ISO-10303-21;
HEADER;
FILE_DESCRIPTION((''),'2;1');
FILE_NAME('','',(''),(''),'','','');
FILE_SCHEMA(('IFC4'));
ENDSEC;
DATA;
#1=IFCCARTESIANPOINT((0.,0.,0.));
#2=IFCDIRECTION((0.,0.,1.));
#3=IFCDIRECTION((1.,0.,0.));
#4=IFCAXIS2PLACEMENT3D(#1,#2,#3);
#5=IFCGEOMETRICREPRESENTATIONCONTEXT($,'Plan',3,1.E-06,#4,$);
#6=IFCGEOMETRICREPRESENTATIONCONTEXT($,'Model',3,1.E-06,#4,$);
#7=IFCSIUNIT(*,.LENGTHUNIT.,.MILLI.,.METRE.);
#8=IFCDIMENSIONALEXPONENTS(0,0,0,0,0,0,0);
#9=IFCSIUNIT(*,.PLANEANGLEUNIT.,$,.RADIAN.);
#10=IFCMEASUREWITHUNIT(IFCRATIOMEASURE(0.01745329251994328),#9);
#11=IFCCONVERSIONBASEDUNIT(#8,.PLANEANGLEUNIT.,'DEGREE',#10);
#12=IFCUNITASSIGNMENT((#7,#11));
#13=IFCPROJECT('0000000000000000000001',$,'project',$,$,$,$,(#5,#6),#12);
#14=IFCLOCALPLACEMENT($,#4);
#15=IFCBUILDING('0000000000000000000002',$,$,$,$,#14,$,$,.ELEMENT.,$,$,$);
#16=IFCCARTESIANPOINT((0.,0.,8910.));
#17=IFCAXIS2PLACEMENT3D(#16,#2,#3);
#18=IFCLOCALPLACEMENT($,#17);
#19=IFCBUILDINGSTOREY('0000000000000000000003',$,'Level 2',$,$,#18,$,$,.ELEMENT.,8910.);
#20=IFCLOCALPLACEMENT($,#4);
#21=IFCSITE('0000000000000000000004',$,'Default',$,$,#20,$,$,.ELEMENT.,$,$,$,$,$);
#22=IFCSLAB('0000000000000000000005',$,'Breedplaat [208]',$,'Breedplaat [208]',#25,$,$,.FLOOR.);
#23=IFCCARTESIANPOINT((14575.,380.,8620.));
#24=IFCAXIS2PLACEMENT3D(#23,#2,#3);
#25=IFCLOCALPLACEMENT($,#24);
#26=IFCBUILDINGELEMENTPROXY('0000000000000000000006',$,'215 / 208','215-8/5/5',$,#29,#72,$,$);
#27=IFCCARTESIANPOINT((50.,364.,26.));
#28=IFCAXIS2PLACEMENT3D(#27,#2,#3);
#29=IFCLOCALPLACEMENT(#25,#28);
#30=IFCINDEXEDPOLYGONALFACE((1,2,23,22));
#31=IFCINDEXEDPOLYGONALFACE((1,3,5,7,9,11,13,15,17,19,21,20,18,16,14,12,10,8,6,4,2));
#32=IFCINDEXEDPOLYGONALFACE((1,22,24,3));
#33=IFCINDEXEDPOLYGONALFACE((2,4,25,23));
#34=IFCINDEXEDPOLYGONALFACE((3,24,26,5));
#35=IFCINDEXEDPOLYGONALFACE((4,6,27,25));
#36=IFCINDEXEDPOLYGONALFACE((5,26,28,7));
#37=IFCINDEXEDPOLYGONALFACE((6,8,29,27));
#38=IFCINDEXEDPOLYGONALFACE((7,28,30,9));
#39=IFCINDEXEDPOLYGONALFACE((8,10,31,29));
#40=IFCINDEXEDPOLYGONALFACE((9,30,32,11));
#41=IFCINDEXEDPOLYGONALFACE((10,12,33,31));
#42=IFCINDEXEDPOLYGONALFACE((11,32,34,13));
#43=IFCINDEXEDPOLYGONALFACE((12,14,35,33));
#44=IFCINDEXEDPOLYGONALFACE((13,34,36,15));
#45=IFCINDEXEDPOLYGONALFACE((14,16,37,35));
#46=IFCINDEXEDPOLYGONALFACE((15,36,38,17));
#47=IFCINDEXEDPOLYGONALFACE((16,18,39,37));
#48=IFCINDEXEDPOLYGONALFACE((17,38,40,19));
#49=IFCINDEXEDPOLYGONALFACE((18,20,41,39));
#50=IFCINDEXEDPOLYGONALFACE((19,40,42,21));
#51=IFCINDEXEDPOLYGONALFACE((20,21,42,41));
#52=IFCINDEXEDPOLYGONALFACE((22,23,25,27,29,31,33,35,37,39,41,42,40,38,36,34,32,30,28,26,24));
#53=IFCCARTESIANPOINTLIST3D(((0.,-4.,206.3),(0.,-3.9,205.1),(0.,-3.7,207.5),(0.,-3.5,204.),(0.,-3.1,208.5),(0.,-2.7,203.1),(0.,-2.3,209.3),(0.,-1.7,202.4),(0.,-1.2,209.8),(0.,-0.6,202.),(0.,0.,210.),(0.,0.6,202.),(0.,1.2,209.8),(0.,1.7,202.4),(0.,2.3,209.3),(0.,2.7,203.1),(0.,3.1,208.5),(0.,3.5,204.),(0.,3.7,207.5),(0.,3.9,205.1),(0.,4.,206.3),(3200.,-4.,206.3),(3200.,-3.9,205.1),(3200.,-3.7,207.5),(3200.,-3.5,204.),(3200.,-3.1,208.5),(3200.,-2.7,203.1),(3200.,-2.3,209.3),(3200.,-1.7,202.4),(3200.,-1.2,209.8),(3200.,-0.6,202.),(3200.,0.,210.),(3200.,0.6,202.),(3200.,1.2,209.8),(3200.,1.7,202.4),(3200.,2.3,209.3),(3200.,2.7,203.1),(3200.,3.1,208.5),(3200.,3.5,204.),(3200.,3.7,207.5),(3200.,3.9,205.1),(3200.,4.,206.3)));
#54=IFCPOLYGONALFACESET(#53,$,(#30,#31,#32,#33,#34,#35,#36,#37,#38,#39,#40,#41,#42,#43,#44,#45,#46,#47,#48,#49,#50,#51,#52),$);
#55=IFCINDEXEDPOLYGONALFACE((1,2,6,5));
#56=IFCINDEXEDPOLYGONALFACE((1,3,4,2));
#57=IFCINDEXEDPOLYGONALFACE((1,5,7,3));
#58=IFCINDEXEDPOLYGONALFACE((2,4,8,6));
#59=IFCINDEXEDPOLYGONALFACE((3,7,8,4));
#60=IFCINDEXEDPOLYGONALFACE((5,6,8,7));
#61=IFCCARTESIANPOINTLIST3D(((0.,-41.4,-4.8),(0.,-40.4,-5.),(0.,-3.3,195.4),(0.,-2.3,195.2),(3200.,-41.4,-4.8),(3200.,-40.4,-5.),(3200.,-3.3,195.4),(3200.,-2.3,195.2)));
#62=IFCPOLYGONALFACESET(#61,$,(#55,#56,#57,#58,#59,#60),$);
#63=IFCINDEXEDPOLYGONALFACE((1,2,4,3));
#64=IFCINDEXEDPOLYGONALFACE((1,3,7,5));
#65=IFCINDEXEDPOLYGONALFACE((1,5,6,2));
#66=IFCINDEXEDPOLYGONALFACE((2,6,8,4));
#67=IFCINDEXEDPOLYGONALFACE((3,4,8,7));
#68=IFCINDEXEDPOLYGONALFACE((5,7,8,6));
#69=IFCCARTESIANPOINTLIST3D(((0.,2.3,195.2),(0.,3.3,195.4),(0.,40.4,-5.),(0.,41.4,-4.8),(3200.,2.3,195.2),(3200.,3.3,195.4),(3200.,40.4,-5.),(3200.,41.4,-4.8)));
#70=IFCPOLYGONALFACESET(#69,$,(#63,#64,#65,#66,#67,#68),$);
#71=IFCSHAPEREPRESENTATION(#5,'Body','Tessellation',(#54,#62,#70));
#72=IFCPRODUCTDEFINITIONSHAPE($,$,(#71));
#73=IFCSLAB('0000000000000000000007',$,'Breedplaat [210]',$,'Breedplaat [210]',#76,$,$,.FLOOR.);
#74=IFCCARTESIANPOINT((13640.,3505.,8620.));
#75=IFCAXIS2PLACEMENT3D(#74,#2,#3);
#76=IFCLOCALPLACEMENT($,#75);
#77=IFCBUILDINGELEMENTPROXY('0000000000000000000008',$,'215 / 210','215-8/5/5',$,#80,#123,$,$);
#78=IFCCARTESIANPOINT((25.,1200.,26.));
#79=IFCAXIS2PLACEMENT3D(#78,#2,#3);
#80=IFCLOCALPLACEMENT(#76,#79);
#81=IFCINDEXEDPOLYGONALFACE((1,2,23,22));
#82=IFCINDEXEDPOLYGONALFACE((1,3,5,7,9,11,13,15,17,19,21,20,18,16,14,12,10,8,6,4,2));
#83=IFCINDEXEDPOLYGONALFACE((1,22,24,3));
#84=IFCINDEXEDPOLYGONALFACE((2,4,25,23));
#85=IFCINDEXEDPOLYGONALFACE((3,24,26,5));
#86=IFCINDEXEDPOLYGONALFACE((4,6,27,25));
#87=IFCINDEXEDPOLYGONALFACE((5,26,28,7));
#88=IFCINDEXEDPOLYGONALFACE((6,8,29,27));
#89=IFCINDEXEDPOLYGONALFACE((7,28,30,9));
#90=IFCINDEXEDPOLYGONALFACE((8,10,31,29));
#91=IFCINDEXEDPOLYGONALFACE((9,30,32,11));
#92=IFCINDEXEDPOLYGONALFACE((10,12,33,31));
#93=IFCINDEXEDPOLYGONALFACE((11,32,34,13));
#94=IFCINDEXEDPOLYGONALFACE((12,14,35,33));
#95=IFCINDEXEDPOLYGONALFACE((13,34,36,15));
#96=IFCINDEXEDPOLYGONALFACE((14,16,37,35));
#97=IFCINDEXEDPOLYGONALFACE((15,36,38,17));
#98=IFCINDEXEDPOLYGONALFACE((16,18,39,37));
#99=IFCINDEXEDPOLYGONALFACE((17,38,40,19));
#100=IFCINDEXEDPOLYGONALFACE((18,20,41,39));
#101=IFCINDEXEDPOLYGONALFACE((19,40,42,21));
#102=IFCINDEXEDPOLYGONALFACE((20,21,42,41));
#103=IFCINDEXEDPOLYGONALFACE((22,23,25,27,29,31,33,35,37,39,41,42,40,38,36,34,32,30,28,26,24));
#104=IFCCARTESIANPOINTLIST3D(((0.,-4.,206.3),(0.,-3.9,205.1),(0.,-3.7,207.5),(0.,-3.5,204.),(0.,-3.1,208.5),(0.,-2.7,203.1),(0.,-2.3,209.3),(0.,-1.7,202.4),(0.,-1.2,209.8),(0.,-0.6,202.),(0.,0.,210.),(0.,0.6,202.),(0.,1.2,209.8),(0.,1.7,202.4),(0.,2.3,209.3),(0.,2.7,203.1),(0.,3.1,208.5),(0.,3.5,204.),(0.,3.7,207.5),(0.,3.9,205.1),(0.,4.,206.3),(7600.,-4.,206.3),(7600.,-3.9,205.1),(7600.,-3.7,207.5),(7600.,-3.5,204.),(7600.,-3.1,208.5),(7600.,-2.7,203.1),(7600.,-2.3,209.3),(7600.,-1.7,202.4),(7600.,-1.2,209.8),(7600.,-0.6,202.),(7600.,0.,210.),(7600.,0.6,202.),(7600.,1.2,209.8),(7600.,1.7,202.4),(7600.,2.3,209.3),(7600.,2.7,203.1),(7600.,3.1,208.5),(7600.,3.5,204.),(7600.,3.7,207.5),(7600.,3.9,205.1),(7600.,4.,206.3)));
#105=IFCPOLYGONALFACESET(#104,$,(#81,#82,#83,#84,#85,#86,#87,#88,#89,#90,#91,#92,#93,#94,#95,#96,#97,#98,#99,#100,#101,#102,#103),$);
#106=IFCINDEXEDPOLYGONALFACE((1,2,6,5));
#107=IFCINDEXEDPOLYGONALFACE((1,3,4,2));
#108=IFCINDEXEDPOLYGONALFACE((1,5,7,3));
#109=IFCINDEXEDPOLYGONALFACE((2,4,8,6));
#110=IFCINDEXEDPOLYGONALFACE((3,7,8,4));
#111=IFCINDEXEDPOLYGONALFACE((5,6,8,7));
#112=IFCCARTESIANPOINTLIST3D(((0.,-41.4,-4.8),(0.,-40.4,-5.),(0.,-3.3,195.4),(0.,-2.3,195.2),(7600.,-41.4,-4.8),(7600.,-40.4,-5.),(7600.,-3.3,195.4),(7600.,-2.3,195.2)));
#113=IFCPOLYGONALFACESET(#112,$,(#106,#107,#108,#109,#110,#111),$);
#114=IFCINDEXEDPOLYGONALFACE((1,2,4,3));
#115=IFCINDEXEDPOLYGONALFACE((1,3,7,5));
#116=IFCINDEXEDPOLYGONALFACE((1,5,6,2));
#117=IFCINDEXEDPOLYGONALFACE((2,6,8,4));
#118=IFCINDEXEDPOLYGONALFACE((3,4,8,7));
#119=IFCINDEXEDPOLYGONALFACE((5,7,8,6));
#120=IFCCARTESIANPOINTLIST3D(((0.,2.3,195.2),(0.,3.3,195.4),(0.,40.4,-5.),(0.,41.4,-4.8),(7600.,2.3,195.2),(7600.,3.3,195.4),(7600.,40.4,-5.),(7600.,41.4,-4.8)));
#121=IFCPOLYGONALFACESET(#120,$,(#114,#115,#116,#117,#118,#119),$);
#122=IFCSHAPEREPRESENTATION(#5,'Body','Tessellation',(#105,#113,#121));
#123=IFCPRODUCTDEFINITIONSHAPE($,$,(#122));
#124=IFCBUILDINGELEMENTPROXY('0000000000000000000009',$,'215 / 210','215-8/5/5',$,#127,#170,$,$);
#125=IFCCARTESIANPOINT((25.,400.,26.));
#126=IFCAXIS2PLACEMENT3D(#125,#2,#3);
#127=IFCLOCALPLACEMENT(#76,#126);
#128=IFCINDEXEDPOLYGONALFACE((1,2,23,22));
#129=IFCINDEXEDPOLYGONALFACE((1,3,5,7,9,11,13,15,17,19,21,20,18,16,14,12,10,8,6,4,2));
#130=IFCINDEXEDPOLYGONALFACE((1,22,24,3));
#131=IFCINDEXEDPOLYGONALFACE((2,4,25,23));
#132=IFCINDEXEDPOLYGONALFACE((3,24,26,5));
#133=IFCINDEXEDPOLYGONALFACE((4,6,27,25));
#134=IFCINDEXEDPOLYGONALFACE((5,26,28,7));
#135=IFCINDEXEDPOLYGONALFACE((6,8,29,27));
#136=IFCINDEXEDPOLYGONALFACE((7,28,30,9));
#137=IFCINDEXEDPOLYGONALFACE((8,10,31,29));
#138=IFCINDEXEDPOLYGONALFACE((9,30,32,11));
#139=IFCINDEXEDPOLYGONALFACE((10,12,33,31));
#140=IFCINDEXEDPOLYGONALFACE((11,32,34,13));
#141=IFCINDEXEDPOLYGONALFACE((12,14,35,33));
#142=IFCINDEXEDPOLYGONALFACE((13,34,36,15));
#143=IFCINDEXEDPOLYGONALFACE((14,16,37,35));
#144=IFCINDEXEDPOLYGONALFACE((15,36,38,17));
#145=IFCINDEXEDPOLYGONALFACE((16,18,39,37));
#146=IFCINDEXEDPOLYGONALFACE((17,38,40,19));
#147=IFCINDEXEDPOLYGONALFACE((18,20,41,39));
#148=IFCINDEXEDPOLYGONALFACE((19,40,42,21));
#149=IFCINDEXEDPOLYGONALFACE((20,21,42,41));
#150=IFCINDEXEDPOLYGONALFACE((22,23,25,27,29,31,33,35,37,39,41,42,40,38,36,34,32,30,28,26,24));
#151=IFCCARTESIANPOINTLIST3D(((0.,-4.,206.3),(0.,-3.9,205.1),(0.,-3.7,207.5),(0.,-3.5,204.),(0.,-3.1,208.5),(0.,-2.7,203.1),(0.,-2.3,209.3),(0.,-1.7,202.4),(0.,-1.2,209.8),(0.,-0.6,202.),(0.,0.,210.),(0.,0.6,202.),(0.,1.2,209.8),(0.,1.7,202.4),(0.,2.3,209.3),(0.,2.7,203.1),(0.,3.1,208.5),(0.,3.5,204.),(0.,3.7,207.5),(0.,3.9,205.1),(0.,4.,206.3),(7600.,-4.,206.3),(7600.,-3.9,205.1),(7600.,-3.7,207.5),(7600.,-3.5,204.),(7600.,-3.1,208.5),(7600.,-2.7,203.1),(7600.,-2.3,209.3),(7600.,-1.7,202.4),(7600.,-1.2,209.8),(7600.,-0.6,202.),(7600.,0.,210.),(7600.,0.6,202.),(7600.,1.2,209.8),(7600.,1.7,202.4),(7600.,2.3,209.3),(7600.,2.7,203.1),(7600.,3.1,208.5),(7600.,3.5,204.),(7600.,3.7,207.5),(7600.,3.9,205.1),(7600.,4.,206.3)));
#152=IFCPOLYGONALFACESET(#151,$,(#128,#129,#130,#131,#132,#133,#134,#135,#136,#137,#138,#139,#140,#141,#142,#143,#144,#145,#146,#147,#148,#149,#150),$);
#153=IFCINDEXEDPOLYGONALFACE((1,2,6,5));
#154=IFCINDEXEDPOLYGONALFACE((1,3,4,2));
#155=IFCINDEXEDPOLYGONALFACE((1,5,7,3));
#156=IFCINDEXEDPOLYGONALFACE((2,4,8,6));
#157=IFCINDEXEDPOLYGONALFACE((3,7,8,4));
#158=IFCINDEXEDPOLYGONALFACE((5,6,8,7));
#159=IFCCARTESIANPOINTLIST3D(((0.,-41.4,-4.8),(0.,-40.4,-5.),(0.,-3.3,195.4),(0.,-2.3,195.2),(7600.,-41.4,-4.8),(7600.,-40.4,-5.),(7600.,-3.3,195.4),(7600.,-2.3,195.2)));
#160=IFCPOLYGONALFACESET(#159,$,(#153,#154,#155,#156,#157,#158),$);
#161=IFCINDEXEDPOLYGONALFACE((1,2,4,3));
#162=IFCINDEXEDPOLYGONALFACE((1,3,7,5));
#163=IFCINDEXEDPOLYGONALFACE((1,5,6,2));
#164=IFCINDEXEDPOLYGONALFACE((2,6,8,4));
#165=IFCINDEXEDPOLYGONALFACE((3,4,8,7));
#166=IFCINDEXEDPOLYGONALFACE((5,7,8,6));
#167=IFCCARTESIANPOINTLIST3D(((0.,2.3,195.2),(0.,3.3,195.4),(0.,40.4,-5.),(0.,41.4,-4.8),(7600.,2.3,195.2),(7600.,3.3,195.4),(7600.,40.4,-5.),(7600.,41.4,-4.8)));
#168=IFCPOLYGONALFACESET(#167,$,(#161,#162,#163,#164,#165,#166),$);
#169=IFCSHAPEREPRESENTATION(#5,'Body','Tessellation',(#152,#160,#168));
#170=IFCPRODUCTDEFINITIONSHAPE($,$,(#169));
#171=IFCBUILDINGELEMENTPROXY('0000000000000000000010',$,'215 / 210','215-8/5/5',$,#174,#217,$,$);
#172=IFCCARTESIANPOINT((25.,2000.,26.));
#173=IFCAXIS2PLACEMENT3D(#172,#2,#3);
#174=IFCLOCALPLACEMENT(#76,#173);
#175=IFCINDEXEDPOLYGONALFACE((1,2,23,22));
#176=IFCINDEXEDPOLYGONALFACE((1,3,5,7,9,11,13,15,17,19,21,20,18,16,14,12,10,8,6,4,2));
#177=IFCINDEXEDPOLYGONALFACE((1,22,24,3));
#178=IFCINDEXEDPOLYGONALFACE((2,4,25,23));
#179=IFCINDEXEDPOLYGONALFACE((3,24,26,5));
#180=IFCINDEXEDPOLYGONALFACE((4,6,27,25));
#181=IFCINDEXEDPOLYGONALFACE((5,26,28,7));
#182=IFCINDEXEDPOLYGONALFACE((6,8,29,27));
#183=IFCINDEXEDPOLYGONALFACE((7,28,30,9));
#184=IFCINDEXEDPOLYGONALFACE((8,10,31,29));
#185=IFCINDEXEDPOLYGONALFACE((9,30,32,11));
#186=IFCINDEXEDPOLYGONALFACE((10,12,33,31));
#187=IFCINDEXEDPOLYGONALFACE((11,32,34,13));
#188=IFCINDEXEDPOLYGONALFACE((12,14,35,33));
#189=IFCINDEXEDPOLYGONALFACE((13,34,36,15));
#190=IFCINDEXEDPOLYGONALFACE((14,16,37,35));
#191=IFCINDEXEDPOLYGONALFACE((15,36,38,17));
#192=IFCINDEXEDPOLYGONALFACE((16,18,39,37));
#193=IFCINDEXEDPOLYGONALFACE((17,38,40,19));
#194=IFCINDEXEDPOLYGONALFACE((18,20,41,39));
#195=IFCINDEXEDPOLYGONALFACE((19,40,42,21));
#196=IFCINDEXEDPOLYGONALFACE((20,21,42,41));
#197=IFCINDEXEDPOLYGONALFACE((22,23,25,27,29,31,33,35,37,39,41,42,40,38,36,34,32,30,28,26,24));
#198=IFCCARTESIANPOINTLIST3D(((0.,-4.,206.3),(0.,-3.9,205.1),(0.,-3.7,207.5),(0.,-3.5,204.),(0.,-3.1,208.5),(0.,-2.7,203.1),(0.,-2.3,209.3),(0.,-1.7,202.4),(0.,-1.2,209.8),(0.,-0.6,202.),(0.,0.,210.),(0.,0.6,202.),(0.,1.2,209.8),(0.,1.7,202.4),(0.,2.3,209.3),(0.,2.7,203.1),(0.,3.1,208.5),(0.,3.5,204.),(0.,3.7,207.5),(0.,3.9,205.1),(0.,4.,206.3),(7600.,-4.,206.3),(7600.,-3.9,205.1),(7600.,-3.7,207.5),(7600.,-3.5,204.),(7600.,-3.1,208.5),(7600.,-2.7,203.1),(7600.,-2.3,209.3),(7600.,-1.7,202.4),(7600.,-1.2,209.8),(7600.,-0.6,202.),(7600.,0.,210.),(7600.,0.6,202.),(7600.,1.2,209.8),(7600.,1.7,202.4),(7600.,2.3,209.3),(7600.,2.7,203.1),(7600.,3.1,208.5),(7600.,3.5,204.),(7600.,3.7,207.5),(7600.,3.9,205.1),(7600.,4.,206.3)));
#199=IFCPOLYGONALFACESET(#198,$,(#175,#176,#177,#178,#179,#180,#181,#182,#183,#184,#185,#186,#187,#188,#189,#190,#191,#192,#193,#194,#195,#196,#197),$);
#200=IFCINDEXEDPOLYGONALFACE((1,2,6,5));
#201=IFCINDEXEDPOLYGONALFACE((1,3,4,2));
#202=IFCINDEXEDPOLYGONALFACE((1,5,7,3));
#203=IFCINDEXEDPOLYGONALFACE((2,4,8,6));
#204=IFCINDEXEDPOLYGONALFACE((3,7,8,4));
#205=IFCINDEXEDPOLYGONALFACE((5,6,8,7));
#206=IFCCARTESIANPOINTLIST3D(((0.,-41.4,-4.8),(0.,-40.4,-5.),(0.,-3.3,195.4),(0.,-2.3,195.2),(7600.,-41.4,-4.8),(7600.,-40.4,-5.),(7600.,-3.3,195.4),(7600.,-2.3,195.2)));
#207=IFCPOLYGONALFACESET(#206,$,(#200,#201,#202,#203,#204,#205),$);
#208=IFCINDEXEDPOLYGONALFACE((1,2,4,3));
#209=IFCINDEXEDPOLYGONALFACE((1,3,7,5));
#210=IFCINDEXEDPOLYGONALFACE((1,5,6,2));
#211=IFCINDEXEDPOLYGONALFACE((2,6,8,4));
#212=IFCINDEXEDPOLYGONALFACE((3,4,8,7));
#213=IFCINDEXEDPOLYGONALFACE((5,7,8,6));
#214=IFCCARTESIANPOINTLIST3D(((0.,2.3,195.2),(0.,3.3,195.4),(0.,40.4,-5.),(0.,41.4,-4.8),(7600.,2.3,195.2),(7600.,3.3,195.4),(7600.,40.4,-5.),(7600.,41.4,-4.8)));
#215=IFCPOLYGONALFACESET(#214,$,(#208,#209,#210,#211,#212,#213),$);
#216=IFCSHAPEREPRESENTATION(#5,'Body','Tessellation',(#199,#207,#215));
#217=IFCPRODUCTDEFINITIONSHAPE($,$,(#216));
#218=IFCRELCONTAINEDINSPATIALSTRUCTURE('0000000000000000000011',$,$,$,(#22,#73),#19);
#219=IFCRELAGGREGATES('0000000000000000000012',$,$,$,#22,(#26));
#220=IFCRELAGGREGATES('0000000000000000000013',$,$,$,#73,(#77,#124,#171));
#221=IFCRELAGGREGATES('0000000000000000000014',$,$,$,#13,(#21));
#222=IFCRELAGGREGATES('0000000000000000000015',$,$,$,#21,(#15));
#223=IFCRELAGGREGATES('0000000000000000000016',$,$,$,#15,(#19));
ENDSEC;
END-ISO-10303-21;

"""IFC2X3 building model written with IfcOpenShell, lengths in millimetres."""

from ifc_helpers import new_model, entity, si_unit, converted_unit, frame, origin_with_axes, origin_2d_with_axis, place, context, project, spatial, rectangle, circle, extrude, element, aggregate, save


model = new_model("IFC2X3")

# Units and contexts
plan_context = context("Plan", 3, precision=1e-06, world=origin_with_axes())
model_context = context("Model", 3, precision=1e-06, world=origin_with_axes())
ifc_project = project(units=[si_unit("LENGTHUNIT", "METRE", prefix="MILLI"), converted_unit("PLANEANGLEUNIT", "DEGREE", entity("IfcRatioMeasure", 0.01745329251994328), si_unit("PLANEANGLEUNIT", "RADIAN"), dimensions=[0, 0, 0, 0, 0, 0, 0])], contexts=[plan_context, model_context])

# Site, building, storey
site_placement = place(None, origin_with_axes())
site = spatial("IfcSite", under=ifc_project, at=site_placement, Name="Default", CompositionType="ELEMENT")
building_placement = place(None, origin_with_axes())
building = spatial("IfcBuilding", under=site, at=building_placement, CompositionType="ELEMENT")
storey_placement = place(None, frame((0.0, 0.0, 8910.0), z_axis=(0.0, 0.0, 1.0), x_axis=(1.0, 0.0, 0.0)))
storey = spatial("IfcBuildingStorey", under=building, at=storey_placement, Name="Level 2", CompositionType="ELEMENT", Elevation=8910.0)

# Slab, building element proxy
slab_1_placement = place(None, frame((14575.0, 380.0, 8620.0), z_axis=(0.0, 0.0, 1.0), x_axis=(1.0, 0.0, 0.0)))
slab_1 = element("IfcSlab", 1, at=slab_1_placement, inside=storey, Name="Breedplaat [208]", ObjectType="Breedplaat [208]", PredefinedType="FLOOR")
proxy_1_placement = place(slab_1_placement, frame((50.0, 364.0, 26.0), z_axis=(0.0, 0.0, 1.0), x_axis=(1.0, 0.0, 0.0)))
proxy_1 = element("IfcBuildingElementProxy", 2, at=proxy_1_placement, Name="215 / 208", Description="215-8/5/5", context=plan_context, shape_type="SweptSolid", body=[
    extrude(circle(Radius=4.0, at=origin_2d_with_axis()), frame((0.0, 0.0, 206.0), z_axis=(1.0, 0.0, 0.0), x_axis=(0.0, 0.0, 1.0)), (0.0, 0.0, 1.0), 3200.0),
    extrude(rectangle(XDim=203.8, YDim=1.0, at=origin_2d_with_axis()), frame((0.0, -21.9, 95.2), z_axis=(1.0, 0.0, 0.0), x_axis=(0.0, 0.187112, 0.982339)), (0.0, 0.0, 1.0), 3200.0),
    extrude(rectangle(XDim=203.8, YDim=1.0, at=origin_2d_with_axis()), frame((0.0, 21.9, 95.2), z_axis=(1.0, 0.0, 0.0), x_axis=(0.0, -0.187112, 0.982339)), (0.0, 0.0, 1.0), 3200.0),
])
aggregate(slab_1, [proxy_1])

# Slab, building element proxies
slab_2_placement = place(None, frame((13640.0, 3505.0, 8620.0), z_axis=(0.0, 0.0, 1.0), x_axis=(1.0, 0.0, 0.0)))
slab_2 = element("IfcSlab", 3, at=slab_2_placement, inside=storey, Name="Breedplaat [210]", ObjectType="Breedplaat [210]", PredefinedType="FLOOR")
proxy_2_placement = place(slab_2_placement, frame((25.0, 1200.0, 26.0), z_axis=(0.0, 0.0, 1.0), x_axis=(1.0, 0.0, 0.0)))
proxy_2 = element("IfcBuildingElementProxy", 4, at=proxy_2_placement, Name="215 / 210", Description="215-8/5/5", context=plan_context, shape_type="SweptSolid", body=[
    extrude(circle(Radius=4.0, at=origin_2d_with_axis()), frame((0.0, 0.0, 206.0), z_axis=(1.0, 0.0, 0.0), x_axis=(0.0, 0.0, 1.0)), (0.0, 0.0, 1.0), 7600.0),
    extrude(rectangle(XDim=203.8, YDim=1.0, at=origin_2d_with_axis()), frame((0.0, -21.9, 95.2), z_axis=(1.0, 0.0, 0.0), x_axis=(0.0, 0.187112, 0.982339)), (0.0, 0.0, 1.0), 7600.0),
    extrude(rectangle(XDim=203.8, YDim=1.0, at=origin_2d_with_axis()), frame((0.0, 21.9, 95.2), z_axis=(1.0, 0.0, 0.0), x_axis=(0.0, -0.187112, 0.982339)), (0.0, 0.0, 1.0), 7600.0),
])
proxy_3_placement = place(slab_2_placement, frame((25.0, 400.0, 26.0), z_axis=(0.0, 0.0, 1.0), x_axis=(1.0, 0.0, 0.0)))
proxy_3 = element("IfcBuildingElementProxy", 5, at=proxy_3_placement, Name="215 / 210", Description="215-8/5/5", context=plan_context, shape_type="SweptSolid", body=[
    extrude(circle(Radius=4.0, at=origin_2d_with_axis()), frame((0.0, 0.0, 206.0), z_axis=(1.0, 0.0, 0.0), x_axis=(0.0, 0.0, 1.0)), (0.0, 0.0, 1.0), 7600.0),
    extrude(rectangle(XDim=203.8, YDim=1.0, at=origin_2d_with_axis()), frame((0.0, -21.9, 95.2), z_axis=(1.0, 0.0, 0.0), x_axis=(0.0, 0.187112, 0.982339)), (0.0, 0.0, 1.0), 7600.0),
    extrude(rectangle(XDim=203.8, YDim=1.0, at=origin_2d_with_axis()), frame((0.0, 21.9, 95.2), z_axis=(1.0, 0.0, 0.0), x_axis=(0.0, -0.187112, 0.982339)), (0.0, 0.0, 1.0), 7600.0),
])
proxy_4_placement = place(slab_2_placement, frame((25.0, 2000.0, 26.0), z_axis=(0.0, 0.0, 1.0), x_axis=(1.0, 0.0, 0.0)))
proxy_4 = element("IfcBuildingElementProxy", 6, at=proxy_4_placement, Name="215 / 210", Description="215-8/5/5", context=plan_context, shape_type="SweptSolid", body=[
    extrude(circle(Radius=4.0, at=origin_2d_with_axis()), frame((0.0, 0.0, 206.0), z_axis=(1.0, 0.0, 0.0), x_axis=(0.0, 0.0, 1.0)), (0.0, 0.0, 1.0), 7600.0),
    extrude(rectangle(XDim=203.8, YDim=1.0, at=origin_2d_with_axis()), frame((0.0, -21.9, 95.2), z_axis=(1.0, 0.0, 0.0), x_axis=(0.0, 0.187112, 0.982339)), (0.0, 0.0, 1.0), 7600.0),
    extrude(rectangle(XDim=203.8, YDim=1.0, at=origin_2d_with_axis()), frame((0.0, 21.9, 95.2), z_axis=(1.0, 0.0, 0.0), x_axis=(0.0, -0.187112, 0.982339)), (0.0, 0.0, 1.0), 7600.0),
])
aggregate(slab_2, [proxy_2, proxy_3, proxy_4])

save(model, "model.ifc")
